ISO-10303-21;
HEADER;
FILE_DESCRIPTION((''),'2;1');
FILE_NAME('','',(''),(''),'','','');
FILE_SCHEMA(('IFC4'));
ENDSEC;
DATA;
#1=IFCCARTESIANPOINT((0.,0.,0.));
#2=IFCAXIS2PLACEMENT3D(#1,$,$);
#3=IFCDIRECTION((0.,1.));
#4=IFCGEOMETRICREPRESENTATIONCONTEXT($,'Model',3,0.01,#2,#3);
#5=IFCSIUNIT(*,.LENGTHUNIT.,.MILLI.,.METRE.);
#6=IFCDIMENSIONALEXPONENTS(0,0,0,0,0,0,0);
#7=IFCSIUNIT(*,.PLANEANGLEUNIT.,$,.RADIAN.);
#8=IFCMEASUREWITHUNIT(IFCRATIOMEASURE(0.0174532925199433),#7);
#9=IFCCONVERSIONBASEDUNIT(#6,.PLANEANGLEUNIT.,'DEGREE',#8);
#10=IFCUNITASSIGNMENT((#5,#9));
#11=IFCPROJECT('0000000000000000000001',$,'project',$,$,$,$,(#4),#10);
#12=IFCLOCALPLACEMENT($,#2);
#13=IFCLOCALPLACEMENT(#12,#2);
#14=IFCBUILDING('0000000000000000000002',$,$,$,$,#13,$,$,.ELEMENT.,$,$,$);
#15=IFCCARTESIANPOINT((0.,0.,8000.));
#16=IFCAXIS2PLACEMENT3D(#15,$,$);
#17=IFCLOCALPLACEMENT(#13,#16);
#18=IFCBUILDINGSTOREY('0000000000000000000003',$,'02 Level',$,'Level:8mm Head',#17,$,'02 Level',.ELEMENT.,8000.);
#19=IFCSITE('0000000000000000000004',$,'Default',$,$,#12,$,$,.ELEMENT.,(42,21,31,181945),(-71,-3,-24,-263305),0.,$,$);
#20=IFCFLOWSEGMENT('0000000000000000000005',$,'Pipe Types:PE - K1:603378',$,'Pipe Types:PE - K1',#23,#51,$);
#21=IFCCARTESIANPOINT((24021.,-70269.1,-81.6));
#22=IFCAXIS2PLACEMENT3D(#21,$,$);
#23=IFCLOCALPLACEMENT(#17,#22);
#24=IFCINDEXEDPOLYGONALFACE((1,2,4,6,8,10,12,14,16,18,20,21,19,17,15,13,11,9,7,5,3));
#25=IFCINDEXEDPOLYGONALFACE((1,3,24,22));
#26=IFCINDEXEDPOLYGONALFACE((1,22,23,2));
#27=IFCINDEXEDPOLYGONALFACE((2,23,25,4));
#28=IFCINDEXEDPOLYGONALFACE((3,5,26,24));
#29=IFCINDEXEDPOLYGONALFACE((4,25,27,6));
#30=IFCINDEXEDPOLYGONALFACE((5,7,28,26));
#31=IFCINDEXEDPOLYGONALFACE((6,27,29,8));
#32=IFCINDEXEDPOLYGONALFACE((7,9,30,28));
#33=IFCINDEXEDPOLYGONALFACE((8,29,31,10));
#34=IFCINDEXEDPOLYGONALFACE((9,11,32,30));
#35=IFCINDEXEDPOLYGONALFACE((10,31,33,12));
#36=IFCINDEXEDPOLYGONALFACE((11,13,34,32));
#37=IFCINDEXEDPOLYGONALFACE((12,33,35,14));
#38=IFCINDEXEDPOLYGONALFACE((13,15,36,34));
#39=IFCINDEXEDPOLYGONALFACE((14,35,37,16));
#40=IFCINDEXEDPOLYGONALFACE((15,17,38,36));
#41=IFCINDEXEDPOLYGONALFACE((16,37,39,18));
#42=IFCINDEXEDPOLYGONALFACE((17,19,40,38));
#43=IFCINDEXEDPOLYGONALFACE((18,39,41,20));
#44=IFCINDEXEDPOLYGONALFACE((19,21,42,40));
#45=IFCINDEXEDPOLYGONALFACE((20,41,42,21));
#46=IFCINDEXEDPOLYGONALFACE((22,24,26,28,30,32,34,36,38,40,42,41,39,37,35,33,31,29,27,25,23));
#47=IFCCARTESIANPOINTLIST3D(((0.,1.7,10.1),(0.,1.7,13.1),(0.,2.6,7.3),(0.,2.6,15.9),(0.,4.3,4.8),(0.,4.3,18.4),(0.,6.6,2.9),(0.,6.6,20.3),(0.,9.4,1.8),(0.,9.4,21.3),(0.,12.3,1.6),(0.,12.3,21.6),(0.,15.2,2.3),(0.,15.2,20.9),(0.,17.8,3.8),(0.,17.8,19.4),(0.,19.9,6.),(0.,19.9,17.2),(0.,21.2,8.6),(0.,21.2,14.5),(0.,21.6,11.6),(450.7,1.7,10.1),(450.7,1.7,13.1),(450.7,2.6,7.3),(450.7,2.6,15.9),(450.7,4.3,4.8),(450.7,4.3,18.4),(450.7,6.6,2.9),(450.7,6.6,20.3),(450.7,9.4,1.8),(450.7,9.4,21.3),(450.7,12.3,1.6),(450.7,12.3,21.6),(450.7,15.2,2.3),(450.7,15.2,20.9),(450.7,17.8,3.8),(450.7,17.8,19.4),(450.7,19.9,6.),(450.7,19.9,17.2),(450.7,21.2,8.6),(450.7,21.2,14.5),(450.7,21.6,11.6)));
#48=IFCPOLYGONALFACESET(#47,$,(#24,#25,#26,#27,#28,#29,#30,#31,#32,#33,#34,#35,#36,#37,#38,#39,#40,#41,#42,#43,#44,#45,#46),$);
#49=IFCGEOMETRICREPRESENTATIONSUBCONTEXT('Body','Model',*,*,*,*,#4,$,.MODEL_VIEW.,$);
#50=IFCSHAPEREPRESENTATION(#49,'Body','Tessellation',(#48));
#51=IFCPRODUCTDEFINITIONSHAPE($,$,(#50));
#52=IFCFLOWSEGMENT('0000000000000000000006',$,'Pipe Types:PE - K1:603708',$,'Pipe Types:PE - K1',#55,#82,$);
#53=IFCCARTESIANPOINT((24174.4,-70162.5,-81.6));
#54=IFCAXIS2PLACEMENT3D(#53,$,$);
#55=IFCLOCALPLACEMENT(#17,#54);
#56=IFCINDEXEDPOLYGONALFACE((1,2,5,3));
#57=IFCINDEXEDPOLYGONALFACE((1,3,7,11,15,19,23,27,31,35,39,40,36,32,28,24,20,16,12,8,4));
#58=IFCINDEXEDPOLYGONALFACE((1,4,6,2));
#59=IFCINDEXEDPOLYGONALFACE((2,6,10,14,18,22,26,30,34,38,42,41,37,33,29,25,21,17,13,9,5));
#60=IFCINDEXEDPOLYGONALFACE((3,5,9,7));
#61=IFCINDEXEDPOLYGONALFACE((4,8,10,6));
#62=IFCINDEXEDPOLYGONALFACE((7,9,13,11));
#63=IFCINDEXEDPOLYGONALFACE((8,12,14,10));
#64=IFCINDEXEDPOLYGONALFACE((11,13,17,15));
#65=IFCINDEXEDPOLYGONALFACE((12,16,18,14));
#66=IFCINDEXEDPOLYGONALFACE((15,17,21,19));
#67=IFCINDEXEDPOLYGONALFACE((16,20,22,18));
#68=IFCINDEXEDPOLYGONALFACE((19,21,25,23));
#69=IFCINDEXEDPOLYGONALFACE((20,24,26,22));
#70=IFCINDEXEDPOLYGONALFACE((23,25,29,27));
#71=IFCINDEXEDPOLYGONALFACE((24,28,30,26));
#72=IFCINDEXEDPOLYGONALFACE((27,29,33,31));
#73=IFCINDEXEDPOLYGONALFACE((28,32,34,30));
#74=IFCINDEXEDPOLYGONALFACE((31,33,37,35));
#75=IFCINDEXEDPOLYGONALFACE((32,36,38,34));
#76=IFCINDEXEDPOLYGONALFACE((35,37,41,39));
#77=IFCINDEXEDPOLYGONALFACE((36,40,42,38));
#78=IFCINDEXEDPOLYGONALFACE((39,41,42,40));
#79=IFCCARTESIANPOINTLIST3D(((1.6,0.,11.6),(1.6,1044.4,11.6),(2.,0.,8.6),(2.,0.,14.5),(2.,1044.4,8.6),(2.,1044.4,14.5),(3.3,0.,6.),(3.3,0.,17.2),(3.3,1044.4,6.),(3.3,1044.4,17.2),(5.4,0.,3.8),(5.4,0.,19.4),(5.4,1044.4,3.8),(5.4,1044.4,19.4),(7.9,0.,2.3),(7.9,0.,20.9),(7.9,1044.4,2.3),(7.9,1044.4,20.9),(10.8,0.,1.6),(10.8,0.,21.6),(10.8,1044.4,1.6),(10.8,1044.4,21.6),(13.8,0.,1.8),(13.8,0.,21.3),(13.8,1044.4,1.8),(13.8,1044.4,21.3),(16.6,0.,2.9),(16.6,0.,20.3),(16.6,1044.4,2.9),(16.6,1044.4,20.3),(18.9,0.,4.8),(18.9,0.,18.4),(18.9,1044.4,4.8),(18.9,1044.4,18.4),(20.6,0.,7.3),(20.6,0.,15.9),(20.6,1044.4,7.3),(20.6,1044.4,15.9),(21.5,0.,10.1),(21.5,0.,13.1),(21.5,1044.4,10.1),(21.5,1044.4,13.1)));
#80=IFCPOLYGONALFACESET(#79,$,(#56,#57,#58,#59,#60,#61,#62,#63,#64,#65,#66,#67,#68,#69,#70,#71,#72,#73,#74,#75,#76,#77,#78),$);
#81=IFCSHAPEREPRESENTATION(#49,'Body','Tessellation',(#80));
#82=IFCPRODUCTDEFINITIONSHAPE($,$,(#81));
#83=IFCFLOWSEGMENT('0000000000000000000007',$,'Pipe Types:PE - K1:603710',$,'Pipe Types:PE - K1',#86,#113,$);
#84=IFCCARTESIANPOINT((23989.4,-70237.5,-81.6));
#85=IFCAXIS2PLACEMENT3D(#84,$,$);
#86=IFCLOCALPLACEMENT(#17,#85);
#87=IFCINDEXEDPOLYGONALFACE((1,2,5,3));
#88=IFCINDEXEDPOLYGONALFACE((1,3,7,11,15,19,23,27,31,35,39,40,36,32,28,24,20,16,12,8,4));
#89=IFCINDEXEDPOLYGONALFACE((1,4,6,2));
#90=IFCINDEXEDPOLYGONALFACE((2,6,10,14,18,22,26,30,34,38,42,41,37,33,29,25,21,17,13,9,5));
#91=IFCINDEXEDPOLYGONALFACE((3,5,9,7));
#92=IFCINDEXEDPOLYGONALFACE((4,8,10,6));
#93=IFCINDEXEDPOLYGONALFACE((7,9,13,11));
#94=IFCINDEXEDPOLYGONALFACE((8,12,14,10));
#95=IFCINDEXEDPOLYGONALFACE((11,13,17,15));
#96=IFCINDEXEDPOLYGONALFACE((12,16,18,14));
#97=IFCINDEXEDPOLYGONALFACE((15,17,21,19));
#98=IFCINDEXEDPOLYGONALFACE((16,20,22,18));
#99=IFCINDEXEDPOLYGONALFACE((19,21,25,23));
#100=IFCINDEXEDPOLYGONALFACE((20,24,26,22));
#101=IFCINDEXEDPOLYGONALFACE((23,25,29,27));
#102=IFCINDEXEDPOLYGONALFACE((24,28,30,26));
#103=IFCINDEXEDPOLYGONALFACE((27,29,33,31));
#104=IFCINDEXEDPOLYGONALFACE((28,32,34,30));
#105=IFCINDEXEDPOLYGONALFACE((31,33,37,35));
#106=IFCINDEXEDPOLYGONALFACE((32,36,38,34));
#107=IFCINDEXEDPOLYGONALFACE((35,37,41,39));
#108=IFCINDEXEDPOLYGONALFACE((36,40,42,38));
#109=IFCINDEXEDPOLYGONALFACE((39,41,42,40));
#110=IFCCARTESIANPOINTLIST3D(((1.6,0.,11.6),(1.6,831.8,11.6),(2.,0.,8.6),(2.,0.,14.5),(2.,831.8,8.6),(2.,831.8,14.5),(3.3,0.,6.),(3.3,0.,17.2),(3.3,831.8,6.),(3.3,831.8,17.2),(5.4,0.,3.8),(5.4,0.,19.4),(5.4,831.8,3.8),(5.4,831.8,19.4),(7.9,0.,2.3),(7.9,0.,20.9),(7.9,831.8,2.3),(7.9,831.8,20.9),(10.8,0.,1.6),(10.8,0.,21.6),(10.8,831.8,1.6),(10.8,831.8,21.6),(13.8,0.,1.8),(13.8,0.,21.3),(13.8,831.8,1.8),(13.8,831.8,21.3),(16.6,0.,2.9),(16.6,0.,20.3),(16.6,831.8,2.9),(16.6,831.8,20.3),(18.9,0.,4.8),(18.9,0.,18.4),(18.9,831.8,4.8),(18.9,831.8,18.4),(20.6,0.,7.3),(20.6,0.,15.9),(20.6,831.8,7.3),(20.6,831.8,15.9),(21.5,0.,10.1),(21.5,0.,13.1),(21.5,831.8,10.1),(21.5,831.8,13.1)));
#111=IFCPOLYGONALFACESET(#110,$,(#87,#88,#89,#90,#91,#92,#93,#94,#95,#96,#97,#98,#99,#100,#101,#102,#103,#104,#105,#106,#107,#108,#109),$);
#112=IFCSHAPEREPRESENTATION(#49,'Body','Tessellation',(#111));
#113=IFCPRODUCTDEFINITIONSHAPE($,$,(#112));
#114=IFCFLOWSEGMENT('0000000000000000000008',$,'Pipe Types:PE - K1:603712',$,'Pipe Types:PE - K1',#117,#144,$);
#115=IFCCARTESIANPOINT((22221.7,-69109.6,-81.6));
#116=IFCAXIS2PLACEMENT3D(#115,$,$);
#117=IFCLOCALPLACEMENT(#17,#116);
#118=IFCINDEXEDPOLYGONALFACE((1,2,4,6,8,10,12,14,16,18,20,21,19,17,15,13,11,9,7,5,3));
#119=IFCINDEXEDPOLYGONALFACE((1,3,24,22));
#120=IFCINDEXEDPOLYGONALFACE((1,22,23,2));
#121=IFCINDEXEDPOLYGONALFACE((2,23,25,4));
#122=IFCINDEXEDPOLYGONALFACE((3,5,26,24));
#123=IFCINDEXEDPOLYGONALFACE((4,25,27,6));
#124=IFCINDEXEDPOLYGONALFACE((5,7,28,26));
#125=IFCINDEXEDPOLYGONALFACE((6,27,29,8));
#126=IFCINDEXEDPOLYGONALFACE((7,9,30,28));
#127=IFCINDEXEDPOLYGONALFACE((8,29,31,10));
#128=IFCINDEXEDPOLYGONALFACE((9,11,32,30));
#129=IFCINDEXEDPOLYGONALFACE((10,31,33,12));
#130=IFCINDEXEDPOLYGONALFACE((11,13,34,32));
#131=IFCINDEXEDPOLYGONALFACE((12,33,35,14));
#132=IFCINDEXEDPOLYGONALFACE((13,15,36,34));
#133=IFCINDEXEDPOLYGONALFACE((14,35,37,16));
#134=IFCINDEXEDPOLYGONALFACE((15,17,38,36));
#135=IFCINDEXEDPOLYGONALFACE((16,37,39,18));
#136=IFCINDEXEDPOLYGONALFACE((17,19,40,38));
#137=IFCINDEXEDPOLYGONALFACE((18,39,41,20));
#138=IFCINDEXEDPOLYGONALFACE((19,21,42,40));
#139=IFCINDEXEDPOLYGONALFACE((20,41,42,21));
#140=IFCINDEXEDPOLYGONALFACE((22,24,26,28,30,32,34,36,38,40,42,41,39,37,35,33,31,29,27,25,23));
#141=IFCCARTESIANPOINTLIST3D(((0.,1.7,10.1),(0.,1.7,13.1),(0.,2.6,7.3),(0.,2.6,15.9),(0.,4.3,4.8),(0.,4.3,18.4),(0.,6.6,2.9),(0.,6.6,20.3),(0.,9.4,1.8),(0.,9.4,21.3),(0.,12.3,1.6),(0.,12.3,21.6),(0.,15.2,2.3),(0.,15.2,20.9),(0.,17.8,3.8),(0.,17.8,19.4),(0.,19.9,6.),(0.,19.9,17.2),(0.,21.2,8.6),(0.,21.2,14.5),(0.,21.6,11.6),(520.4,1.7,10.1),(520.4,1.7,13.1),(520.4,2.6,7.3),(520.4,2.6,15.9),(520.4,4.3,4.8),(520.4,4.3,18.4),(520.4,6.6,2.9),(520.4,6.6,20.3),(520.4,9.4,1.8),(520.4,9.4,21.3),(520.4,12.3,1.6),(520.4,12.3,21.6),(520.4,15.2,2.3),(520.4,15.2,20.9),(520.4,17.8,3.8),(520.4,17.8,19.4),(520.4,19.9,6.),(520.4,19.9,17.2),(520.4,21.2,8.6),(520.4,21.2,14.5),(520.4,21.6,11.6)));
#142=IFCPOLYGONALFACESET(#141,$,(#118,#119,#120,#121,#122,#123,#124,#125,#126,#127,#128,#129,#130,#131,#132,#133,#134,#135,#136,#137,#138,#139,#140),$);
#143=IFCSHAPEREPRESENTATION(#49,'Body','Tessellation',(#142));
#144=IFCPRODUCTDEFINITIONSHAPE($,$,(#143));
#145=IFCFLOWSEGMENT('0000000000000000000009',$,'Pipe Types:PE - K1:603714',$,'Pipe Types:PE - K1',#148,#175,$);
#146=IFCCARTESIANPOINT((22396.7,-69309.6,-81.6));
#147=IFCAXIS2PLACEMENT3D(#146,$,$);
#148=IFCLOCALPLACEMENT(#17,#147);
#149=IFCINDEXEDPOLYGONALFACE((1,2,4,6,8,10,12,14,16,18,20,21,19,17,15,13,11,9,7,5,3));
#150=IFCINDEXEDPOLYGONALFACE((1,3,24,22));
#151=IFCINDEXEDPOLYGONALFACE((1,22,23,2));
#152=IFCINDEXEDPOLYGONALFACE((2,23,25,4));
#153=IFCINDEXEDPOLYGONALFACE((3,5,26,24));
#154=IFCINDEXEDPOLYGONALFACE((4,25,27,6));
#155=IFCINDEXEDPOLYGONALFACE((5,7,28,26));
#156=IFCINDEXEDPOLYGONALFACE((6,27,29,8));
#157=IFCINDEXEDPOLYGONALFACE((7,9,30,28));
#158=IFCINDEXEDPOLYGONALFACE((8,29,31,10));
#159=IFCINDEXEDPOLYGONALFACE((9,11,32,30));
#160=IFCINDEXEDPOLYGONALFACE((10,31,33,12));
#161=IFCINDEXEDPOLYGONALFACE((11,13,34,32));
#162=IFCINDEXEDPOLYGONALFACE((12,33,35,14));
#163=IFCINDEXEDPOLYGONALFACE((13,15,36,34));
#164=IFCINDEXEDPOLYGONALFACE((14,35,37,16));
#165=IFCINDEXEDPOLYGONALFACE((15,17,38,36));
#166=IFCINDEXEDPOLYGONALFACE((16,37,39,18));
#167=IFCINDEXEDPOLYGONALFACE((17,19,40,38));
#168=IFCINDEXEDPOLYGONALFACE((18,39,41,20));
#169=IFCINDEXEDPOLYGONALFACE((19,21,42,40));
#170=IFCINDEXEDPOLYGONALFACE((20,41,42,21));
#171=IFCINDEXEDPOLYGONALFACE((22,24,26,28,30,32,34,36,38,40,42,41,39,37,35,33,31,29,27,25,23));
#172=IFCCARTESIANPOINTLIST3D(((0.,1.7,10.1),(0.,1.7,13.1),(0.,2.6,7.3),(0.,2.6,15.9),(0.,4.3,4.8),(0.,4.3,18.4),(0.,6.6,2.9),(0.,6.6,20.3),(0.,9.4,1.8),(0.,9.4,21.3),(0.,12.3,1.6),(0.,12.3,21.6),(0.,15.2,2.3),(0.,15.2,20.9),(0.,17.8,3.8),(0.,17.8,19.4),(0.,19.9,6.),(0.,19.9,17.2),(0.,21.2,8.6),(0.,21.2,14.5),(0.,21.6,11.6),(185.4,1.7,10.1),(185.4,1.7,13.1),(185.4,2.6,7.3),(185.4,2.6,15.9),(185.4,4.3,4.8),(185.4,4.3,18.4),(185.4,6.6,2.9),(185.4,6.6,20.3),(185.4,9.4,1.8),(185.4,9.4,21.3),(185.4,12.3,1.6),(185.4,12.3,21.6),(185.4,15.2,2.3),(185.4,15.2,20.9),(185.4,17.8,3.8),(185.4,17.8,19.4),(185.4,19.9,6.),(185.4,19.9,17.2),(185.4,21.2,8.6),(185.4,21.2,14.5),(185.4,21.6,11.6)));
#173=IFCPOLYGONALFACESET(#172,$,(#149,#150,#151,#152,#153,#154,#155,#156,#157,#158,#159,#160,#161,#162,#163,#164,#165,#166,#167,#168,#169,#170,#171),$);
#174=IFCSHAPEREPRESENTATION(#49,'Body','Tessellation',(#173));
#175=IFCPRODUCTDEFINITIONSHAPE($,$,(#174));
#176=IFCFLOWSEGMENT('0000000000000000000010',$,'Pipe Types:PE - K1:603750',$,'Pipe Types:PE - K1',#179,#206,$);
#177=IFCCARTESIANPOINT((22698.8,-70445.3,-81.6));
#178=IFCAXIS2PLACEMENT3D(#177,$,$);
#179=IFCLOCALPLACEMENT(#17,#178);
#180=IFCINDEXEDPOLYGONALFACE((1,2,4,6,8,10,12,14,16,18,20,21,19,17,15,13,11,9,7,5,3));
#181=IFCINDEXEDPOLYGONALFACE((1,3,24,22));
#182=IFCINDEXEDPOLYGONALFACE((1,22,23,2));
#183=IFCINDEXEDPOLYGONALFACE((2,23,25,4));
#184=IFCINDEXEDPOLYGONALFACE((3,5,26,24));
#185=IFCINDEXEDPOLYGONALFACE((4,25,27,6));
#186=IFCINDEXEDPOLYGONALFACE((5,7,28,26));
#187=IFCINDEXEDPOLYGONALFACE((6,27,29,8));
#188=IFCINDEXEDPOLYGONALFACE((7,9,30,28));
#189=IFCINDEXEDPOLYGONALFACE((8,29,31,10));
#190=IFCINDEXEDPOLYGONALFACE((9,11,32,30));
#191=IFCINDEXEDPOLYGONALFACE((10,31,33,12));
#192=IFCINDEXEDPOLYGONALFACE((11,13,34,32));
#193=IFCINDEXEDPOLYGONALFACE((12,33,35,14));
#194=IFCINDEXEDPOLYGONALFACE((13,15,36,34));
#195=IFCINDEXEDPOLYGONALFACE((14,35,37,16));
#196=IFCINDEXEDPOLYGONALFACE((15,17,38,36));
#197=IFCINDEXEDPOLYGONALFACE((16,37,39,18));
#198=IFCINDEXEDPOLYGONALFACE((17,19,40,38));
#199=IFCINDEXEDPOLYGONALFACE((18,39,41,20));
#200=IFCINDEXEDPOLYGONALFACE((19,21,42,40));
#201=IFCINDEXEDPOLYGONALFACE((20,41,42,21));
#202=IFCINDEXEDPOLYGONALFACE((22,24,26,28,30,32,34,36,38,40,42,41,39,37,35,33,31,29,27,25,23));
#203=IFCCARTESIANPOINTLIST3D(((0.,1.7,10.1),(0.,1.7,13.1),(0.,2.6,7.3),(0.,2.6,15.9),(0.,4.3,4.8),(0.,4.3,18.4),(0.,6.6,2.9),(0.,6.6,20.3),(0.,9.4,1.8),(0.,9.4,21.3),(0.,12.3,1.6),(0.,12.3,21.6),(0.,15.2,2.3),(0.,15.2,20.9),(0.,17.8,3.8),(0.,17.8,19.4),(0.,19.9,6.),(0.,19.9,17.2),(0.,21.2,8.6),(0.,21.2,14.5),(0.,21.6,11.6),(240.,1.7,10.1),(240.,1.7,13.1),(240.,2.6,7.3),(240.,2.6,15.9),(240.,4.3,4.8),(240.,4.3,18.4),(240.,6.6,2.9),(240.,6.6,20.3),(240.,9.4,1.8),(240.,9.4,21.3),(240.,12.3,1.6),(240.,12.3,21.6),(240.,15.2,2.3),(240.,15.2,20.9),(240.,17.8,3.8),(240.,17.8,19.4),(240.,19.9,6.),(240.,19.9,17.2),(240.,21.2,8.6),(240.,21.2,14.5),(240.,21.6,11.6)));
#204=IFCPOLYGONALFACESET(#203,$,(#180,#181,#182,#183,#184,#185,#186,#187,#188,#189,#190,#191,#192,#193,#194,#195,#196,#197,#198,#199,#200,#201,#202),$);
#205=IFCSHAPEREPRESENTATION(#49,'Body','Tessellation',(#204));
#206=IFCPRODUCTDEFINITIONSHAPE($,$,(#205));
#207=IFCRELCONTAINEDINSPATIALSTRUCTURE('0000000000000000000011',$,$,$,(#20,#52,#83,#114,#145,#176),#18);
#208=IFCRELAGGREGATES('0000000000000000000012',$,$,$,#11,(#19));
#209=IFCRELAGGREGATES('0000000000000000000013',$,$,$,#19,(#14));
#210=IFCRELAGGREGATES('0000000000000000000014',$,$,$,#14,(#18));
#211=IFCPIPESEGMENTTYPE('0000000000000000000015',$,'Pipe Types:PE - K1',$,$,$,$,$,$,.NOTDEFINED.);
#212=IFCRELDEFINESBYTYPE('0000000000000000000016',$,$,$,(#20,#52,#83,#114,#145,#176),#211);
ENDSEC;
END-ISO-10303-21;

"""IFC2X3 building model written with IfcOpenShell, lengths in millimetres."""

from ifc_helpers import new_model, entity, si_unit, converted_unit, direction, frame, frame_2d, origin, origin_2d_with_axis, place, context, subcontext, project, spatial, circle, extrude, type_object, element, save


model = new_model("IFC2X3")

# Units and contexts
model_context = context("Model", 3, precision=0.01, world=origin(), true_north=direction((0.0, 1.0)))
body_context = subcontext(model_context, "Body", "Model", "MODEL_VIEW")
ifc_project = project(units=[si_unit("LENGTHUNIT", "METRE", prefix="MILLI"), converted_unit("PLANEANGLEUNIT", "DEGREE", entity("IfcRatioMeasure", 0.0174532925199433), si_unit("PLANEANGLEUNIT", "RADIAN"), dimensions=[0, 0, 0, 0, 0, 0, 0])], contexts=[model_context])

# Site, building, storey
site_placement = place(None, origin())
site = spatial("IfcSite", under=ifc_project, at=site_placement, Name="Default", CompositionType="ELEMENT", RefLatitude=(42, 21, 31, 181945), RefLongitude=(-71, -3, -24, -263305), RefElevation=0.0)
building_placement = place(site_placement, origin())
building = spatial("IfcBuilding", under=site, at=building_placement, CompositionType="ELEMENT")
storey_placement = place(building_placement, frame((0.0, 0.0, 8000.0)))
storey = spatial("IfcBuildingStorey", under=building, at=storey_placement, Name="02 Level", ObjectType="Level:8mm Head", LongName="02 Level", CompositionType="ELEMENT", Elevation=8000.0)

# Flow segments
pipe_segment_type = type_object("IfcPipeSegmentType", Name="Pipe Types:PE - K1", PredefinedType="NOTDEFINED")
flow_segment_1_placement = place(storey_placement, frame((24021.0, -70269.1, -81.6)))
element("IfcFlowSegment", 1, at=flow_segment_1_placement, inside=storey, type_object=pipe_segment_type, Name="Pipe Types:PE - K1:603378", ObjectType="Pipe Types:PE - K1", context=body_context, shape_type="SweptSolid", body=[
    extrude(circle(Radius=10.0, at=frame_2d((0.0, 0.0), x_axis=(1.0, 0.0))), frame((0.0, 11.6, 11.6), z_axis=(1.0, 0.0, 0.0), x_axis=(0.0, 1.0, 0.0)), (0.0, 0.0, 1.0), 450.7),
])
flow_segment_2_placement = place(storey_placement, frame((24174.4, -70162.5, -81.6)))
element("IfcFlowSegment", 2, at=flow_segment_2_placement, inside=storey, type_object=pipe_segment_type, Name="Pipe Types:PE - K1:603708", ObjectType="Pipe Types:PE - K1", context=body_context, shape_type="SweptSolid", body=[
    extrude(circle(Radius=10.0, at=frame_2d((0.0, 0.0), x_axis=(1.0, 0.0))), frame((11.6, 0.0, 11.6), z_axis=(0.0, 1.0, 0.0), x_axis=(-1.0, 0.0, 0.0)), (0.0, 0.0, 1.0), 1044.4),
])
flow_segment_3_placement = place(storey_placement, frame((23989.4, -70237.5, -81.6)))
element("IfcFlowSegment", 3, at=flow_segment_3_placement, inside=storey, type_object=pipe_segment_type, Name="Pipe Types:PE - K1:603710", ObjectType="Pipe Types:PE - K1", context=body_context, shape_type="SweptSolid", body=[
    extrude(circle(Radius=10.0, at=frame_2d((0.0, 0.0), x_axis=(1.0, 0.0))), frame((11.6, 0.0, 11.6), z_axis=(0.0, 1.0, 0.0), x_axis=(-1.0, 0.0, 0.0)), (0.0, 0.0, 1.0), 831.8),
])
flow_segment_4_placement = place(storey_placement, frame((22221.7, -69109.6, -81.6)))
element("IfcFlowSegment", 4, at=flow_segment_4_placement, inside=storey, type_object=pipe_segment_type, Name="Pipe Types:PE - K1:603712", ObjectType="Pipe Types:PE - K1", context=body_context, shape_type="SweptSolid", body=[
    extrude(circle(Radius=10.0, at=frame_2d((0.0, 0.0), x_axis=(1.0, 0.0))), frame((0.0, 11.6, 11.6), z_axis=(1.0, 0.0, 0.0), x_axis=(0.0, 1.0, 0.0)), (0.0, 0.0, 1.0), 520.4),
])
flow_segment_5_placement = place(storey_placement, frame((22396.7, -69309.6, -81.6)))
element("IfcFlowSegment", 5, at=flow_segment_5_placement, inside=storey, type_object=pipe_segment_type, Name="Pipe Types:PE - K1:603714", ObjectType="Pipe Types:PE - K1", context=body_context, shape_type="SweptSolid", body=[
    extrude(circle(Radius=10.0, at=origin_2d_with_axis()), frame((0.0, 11.6, 11.6), z_axis=(1.0, 0.0, 0.0), x_axis=(0.0, 1.0, 0.0)), (0.0, 0.0, 1.0), 185.4),
])
flow_segment_6_placement = place(storey_placement, frame((22698.8, -70445.3, -81.6)))
element("IfcFlowSegment", 6, at=flow_segment_6_placement, inside=storey, type_object=pipe_segment_type, Name="Pipe Types:PE - K1:603750", ObjectType="Pipe Types:PE - K1", context=body_context, shape_type="SweptSolid", body=[
    extrude(circle(Radius=10.0, at=origin_2d_with_axis()), frame((0.0, 11.6, 11.6), z_axis=(1.0, 0.0, 0.0), x_axis=(0.0, 1.0, 0.0)), (0.0, 0.0, 1.0), 240.0),
])

save(model, "model.ifc")
